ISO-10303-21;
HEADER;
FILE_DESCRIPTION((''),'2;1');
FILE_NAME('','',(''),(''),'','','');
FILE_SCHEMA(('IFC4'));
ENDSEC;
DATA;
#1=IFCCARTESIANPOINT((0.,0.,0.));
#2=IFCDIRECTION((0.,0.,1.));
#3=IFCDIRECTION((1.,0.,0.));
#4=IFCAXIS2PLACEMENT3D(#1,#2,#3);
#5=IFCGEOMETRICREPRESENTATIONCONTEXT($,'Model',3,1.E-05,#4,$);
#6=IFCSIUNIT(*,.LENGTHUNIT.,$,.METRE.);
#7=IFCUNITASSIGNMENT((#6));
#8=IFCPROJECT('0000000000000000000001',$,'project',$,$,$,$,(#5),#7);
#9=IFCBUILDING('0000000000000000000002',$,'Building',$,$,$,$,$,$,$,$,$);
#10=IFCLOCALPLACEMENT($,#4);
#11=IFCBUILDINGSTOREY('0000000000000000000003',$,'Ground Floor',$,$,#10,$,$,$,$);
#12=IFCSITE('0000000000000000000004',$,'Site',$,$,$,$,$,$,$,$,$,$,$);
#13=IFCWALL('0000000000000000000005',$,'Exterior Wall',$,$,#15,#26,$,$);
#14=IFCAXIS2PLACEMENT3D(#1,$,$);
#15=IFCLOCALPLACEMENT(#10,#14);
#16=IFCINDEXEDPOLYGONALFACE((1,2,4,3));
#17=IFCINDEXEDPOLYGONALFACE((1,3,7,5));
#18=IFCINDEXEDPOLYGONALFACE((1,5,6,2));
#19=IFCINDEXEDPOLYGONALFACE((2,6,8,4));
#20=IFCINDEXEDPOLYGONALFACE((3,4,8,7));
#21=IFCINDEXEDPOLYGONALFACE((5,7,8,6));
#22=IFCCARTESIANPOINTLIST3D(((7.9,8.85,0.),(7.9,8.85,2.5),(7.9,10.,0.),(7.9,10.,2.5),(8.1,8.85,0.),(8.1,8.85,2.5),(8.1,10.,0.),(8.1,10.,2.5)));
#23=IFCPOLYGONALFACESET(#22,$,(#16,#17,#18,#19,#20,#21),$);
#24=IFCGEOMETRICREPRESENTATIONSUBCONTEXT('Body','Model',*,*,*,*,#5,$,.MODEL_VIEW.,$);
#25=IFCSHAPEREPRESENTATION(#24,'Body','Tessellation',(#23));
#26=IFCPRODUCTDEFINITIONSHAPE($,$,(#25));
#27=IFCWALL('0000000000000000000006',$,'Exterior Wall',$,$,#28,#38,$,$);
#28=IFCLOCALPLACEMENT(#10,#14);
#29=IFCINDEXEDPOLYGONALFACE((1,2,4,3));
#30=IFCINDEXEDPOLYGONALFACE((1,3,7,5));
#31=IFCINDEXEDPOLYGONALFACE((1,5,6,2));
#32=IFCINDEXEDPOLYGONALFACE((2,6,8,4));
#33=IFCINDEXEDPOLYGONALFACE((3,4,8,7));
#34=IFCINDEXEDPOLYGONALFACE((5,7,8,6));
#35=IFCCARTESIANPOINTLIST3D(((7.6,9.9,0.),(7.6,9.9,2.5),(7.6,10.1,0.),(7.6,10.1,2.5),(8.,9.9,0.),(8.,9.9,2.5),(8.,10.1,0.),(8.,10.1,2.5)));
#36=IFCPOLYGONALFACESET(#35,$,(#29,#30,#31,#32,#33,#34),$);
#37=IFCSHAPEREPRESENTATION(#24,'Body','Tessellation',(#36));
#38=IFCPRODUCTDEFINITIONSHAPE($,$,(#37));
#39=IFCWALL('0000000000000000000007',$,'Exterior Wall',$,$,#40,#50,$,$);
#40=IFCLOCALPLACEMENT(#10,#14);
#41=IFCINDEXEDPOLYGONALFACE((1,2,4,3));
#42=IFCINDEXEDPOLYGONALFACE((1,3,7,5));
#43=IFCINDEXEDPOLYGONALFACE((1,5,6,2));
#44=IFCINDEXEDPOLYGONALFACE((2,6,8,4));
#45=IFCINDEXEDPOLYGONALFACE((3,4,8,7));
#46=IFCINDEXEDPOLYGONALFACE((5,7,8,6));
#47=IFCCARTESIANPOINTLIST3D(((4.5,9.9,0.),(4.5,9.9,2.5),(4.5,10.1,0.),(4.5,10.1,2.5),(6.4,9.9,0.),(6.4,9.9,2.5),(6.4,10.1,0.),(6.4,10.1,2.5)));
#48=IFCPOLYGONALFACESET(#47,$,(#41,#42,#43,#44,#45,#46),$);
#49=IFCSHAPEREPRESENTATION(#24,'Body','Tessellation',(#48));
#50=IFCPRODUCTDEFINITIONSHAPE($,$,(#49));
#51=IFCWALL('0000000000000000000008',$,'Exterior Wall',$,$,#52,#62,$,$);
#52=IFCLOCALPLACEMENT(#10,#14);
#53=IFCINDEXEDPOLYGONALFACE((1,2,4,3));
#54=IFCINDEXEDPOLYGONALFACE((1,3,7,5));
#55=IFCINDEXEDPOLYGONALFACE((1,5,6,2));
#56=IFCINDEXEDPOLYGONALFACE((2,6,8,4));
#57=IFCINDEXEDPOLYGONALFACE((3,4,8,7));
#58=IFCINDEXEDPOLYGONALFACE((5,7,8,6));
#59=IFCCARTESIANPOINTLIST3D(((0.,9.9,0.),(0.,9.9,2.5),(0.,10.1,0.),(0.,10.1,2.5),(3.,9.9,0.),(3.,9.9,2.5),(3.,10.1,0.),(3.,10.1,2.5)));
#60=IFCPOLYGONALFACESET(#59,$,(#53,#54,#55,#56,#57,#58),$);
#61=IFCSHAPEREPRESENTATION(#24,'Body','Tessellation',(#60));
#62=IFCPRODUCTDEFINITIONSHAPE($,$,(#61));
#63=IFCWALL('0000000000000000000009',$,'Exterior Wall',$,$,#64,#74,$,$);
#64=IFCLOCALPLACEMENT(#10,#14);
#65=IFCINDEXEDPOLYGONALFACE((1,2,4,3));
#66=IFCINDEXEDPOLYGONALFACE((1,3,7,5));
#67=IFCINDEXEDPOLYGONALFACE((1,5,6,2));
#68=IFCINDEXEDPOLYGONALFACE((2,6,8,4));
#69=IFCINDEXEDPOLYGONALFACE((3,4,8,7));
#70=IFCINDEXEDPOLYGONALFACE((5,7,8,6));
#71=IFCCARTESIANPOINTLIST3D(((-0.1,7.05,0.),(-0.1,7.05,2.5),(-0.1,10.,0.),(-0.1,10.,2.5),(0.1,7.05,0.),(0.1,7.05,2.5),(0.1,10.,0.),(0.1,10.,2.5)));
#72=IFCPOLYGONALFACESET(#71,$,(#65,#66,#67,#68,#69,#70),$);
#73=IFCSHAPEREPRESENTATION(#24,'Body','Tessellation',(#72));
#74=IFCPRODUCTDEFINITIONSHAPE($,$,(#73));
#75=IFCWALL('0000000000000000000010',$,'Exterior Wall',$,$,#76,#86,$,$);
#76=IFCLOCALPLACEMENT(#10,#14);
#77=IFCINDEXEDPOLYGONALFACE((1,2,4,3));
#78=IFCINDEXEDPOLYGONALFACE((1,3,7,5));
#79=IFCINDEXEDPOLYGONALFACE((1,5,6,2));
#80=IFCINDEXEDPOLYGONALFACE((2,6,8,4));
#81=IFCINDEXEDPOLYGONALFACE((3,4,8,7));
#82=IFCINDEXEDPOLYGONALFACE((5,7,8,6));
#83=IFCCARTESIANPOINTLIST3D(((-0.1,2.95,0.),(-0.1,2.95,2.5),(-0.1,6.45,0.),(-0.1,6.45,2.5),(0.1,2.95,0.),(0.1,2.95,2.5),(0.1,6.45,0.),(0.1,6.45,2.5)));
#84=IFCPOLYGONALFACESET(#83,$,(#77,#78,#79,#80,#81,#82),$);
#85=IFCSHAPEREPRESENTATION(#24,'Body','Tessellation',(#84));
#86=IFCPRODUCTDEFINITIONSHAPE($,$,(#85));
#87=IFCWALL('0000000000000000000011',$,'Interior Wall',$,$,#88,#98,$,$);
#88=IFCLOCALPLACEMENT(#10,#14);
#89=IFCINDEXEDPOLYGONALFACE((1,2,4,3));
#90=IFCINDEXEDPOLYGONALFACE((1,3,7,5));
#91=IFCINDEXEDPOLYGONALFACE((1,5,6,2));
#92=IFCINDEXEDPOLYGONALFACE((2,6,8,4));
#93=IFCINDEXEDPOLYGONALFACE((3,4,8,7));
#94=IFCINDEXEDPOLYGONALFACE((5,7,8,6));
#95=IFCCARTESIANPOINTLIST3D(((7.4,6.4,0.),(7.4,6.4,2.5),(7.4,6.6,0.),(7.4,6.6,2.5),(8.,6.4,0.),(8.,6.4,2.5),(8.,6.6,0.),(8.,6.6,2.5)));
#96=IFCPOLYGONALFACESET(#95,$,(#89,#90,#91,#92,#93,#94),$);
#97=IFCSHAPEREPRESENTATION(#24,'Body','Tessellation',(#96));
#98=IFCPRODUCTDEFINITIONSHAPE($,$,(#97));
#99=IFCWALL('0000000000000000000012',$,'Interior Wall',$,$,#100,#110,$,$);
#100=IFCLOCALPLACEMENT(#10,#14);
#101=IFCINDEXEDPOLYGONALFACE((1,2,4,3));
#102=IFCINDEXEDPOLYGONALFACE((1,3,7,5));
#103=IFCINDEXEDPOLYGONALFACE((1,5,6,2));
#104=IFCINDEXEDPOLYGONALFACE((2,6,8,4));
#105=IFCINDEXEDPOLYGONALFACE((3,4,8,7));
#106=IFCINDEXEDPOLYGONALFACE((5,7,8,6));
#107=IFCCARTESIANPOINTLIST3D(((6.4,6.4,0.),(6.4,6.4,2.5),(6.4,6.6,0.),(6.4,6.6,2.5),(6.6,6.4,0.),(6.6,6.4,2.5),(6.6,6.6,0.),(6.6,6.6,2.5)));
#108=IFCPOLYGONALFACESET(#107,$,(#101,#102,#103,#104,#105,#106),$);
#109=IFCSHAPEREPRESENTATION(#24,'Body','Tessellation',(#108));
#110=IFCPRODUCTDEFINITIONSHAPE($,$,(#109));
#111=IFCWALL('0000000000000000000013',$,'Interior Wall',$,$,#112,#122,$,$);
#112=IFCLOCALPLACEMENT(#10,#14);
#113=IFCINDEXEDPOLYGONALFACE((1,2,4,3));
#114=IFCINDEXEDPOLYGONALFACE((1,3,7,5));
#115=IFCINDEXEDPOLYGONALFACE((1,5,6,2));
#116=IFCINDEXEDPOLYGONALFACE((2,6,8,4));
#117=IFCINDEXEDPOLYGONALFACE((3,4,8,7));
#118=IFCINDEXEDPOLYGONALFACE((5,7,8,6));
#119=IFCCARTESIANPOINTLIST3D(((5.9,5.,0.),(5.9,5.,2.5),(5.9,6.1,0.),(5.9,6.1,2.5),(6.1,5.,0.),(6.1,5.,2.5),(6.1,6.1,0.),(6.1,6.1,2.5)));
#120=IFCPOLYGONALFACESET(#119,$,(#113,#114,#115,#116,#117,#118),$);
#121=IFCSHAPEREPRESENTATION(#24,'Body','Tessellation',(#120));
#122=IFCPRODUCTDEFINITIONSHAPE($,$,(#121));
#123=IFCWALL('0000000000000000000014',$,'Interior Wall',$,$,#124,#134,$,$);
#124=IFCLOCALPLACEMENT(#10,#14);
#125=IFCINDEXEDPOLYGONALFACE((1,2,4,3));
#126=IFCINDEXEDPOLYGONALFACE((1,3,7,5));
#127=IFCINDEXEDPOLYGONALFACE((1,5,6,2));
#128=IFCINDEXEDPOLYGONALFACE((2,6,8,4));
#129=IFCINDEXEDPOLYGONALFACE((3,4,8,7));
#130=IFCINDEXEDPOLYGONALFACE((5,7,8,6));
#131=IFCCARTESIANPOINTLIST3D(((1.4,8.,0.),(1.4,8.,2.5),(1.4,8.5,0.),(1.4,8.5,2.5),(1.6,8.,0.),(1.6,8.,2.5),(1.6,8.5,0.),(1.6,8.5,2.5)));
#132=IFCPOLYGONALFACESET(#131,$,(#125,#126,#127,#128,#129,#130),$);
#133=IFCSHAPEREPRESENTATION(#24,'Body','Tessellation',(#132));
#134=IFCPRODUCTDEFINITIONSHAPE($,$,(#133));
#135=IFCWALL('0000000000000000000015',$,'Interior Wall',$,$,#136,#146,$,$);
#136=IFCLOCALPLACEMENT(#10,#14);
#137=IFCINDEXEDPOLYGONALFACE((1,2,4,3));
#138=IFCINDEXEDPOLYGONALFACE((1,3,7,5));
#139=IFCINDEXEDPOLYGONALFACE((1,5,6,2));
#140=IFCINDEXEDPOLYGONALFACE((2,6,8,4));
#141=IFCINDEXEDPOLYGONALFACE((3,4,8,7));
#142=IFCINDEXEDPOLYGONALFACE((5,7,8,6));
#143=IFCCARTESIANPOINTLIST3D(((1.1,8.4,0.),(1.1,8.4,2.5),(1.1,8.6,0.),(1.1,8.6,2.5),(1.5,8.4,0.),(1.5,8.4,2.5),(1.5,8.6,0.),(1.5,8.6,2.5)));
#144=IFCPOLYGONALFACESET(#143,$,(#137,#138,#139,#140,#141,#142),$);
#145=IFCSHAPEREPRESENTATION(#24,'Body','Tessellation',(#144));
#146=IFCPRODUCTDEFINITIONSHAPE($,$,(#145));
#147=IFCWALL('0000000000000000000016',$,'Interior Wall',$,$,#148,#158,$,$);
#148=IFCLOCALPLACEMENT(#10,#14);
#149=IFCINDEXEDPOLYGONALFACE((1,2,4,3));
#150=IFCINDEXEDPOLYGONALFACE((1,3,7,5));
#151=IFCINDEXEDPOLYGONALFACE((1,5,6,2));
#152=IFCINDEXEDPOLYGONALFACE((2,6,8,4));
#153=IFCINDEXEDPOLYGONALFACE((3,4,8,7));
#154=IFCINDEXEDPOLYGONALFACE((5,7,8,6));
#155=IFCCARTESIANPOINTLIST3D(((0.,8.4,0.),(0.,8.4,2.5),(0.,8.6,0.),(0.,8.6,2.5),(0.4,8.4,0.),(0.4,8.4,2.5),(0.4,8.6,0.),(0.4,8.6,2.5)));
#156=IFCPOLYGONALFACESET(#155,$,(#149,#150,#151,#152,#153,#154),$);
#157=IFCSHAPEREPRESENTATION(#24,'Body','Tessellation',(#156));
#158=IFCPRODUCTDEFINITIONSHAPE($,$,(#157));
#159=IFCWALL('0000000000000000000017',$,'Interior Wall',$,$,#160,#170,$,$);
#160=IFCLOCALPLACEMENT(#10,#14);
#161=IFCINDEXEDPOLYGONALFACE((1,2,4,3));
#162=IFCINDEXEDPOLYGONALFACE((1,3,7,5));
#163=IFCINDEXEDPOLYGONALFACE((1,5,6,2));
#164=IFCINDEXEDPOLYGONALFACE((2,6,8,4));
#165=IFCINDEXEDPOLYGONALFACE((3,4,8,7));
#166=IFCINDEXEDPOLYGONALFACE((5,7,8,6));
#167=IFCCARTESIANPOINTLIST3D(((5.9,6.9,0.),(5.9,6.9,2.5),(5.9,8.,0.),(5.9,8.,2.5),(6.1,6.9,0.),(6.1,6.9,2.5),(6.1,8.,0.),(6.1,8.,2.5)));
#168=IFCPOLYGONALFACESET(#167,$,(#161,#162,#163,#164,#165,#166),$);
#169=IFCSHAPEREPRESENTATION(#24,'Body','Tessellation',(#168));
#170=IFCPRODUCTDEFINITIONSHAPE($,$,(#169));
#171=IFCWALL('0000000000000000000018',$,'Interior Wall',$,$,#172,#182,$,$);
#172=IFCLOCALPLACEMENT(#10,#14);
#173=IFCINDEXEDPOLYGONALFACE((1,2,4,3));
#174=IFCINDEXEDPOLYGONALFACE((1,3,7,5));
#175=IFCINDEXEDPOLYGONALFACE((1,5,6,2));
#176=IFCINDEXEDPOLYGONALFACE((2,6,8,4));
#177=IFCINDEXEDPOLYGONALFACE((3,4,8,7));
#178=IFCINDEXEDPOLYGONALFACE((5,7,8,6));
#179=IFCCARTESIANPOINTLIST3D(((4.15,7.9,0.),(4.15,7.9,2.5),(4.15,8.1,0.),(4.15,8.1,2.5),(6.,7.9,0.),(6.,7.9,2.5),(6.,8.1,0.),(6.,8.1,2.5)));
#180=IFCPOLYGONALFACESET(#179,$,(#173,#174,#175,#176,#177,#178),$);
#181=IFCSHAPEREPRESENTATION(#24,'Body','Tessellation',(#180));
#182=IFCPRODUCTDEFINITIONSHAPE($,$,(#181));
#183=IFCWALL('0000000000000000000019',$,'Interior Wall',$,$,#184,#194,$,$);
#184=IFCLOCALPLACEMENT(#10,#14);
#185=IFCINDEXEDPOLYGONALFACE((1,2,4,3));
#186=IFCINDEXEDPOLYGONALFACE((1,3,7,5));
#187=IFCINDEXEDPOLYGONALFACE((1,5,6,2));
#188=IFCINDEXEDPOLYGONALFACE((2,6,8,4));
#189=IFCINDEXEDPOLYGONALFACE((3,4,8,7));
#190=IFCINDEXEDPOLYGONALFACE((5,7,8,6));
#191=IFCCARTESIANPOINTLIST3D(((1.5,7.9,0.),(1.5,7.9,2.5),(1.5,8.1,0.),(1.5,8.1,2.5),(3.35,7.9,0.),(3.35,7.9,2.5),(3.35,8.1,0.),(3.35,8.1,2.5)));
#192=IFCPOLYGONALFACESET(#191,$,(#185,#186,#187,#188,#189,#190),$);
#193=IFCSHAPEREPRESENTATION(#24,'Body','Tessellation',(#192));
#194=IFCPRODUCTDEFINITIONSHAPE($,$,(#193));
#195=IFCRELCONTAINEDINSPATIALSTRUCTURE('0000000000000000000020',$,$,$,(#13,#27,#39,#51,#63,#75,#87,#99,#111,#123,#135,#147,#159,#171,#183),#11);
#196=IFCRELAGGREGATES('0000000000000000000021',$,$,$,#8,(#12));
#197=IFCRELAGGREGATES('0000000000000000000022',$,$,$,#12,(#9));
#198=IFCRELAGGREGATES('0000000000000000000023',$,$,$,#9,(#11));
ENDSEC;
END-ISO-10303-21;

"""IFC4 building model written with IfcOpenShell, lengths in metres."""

from ifc_helpers import new_model, si_unit, frame, origin_with_axes, place, context, subcontext, project, spatial, indexed_curve, outline, extrude, element, save


model = new_model("IFC4")

# Units and contexts
model_context = context("Model", 3, precision=1e-05, world=origin_with_axes())
body_context = subcontext(model_context, "Body", "Model", "MODEL_VIEW")
ifc_project = project(units=[si_unit("LENGTHUNIT", "METRE")], contexts=[model_context])

# Site, building, storey
site = spatial("IfcSite", under=ifc_project, Name="Site")
building = spatial("IfcBuilding", under=site, Name="Building")
storey_placement = place(None, origin_with_axes())
storey = spatial("IfcBuildingStorey", under=building, at=storey_placement, Name="Ground Floor")

# Walls
wall_1_placement = place(storey_placement, frame((8.0, 8.85, 0.0), z_axis=(0.0, 0.0, 1.0), x_axis=(0.0, 1.0, 0.0)))
element("IfcWall", 1, at=wall_1_placement, inside=storey, Name="Exterior Wall", context=body_context, shape_type="SweptSolid", body=[
    extrude(outline(indexed_curve([(0.0, 0.0), (0.0, 0.2), (1.15, 0.2), (1.15, 0.0), (0.0, 0.0)], self_intersect=False)), frame((0.0, -0.1, 0.0), z_axis=(0.0, 0.0, 1.0), x_axis=(1.0, 0.0, 0.0)), (0.0, 0.0, 1.0), 2.5),
])
wall_2_placement = place(storey_placement, frame((8.0, 10.0, 0.0), z_axis=(0.0, 0.0, 1.0), x_axis=(-1.0, 0.0, 0.0)))
element("IfcWall", 2, at=wall_2_placement, inside=storey, Name="Exterior Wall", context=body_context, shape_type="SweptSolid", body=[
    extrude(outline(indexed_curve([(0.0, 0.0), (0.0, 0.2), (0.4, 0.2), (0.4, 0.0), (0.0, 0.0)], self_intersect=False)), frame((0.0, -0.1, 0.0), z_axis=(0.0, 0.0, 1.0), x_axis=(1.0, 0.0, 0.0)), (0.0, 0.0, 1.0), 2.5),
])
wall_3_placement = place(storey_placement, frame((6.4, 10.0, 0.0), z_axis=(0.0, 0.0, 1.0), x_axis=(-1.0, 0.0, 0.0)))
element("IfcWall", 3, at=wall_3_placement, inside=storey, Name="Exterior Wall", context=body_context, shape_type="SweptSolid", body=[
    extrude(outline(indexed_curve([(0.0, 0.0), (0.0, 0.2), (1.9, 0.2), (1.9, 0.0), (0.0, 0.0)], self_intersect=False)), frame((0.0, -0.1, 0.0), z_axis=(0.0, 0.0, 1.0), x_axis=(1.0, 0.0, 0.0)), (0.0, 0.0, 1.0), 2.5),
])
wall_4_placement = place(storey_placement, frame((3.0, 10.0, 0.0), z_axis=(0.0, 0.0, 1.0), x_axis=(-1.0, 0.0, 0.0)))
element("IfcWall", 4, at=wall_4_placement, inside=storey, Name="Exterior Wall", context=body_context, shape_type="SweptSolid", body=[
    extrude(outline(indexed_curve([(0.0, 0.0), (0.0, 0.2), (3.0, 0.2), (3.0, 0.0), (0.0, 0.0)], self_intersect=False)), frame((0.0, -0.1, 0.0), z_axis=(0.0, 0.0, 1.0), x_axis=(1.0, 0.0, 0.0)), (0.0, 0.0, 1.0), 2.5),
])
wall_5_placement = place(storey_placement, frame((0.0, 10.0, 0.0), z_axis=(0.0, 0.0, 1.0), x_axis=(0.0, -1.0, 0.0)))
element("IfcWall", 5, at=wall_5_placement, inside=storey, Name="Exterior Wall", context=body_context, shape_type="SweptSolid", body=[
    extrude(outline(indexed_curve([(0.0, 0.0), (0.0, 0.2), (2.95, 0.2), (2.95, 0.0), (0.0, 0.0)], self_intersect=False)), frame((0.0, -0.1, 0.0), z_axis=(0.0, 0.0, 1.0), x_axis=(1.0, 0.0, 0.0)), (0.0, 0.0, 1.0), 2.5),
])
wall_6_placement = place(storey_placement, frame((0.0, 6.45, 0.0), z_axis=(0.0, 0.0, 1.0), x_axis=(0.0, -1.0, 0.0)))
element("IfcWall", 6, at=wall_6_placement, inside=storey, Name="Exterior Wall", context=body_context, shape_type="SweptSolid", body=[
    extrude(outline(indexed_curve([(0.0, 0.0), (0.0, 0.2), (3.5, 0.2), (3.5, 0.0), (0.0, 0.0)], self_intersect=False)), frame((0.0, -0.1, 0.0), z_axis=(0.0, 0.0, 1.0), x_axis=(1.0, 0.0, 0.0)), (0.0, 0.0, 1.0), 2.5),
])
wall_7_placement = place(storey_placement, frame((8.0, 6.5, 0.0), z_axis=(0.0, 0.0, 1.0), x_axis=(-1.0, 0.0, 0.0)))
element("IfcWall", 7, at=wall_7_placement, inside=storey, Name="Interior Wall", context=body_context, shape_type="SweptSolid", body=[
    extrude(outline(indexed_curve([(0.0, 0.0), (0.0, 0.2), (0.6, 0.2), (0.6, 0.0), (0.0, 0.0)], self_intersect=False)), frame((0.0, -0.1, 0.0), z_axis=(0.0, 0.0, 1.0), x_axis=(1.0, 0.0, 0.0)), (0.0, 0.0, 1.0), 2.5),
])
wall_8_placement = place(storey_placement, frame((6.6, 6.5, 0.0), z_axis=(0.0, 0.0, 1.0), x_axis=(-1.0, 0.0, 0.0)))
element("IfcWall", 8, at=wall_8_placement, inside=storey, Name="Interior Wall", context=body_context, shape_type="SweptSolid", body=[
    extrude(outline(indexed_curve([(0.0, 0.0), (0.0, 0.2), (0.2, 0.2), (0.2, 0.0), (0.0, 0.0)], self_intersect=False)), frame((0.0, -0.1, 0.0), z_axis=(0.0, 0.0, 1.0), x_axis=(1.0, 0.0, 0.0)), (0.0, 0.0, 1.0), 2.5),
])
wall_9_placement = place(storey_placement, frame((6.0, 6.1, 0.0), z_axis=(0.0, 0.0, 1.0), x_axis=(0.0, -1.0, 0.0)))
element("IfcWall", 9, at=wall_9_placement, inside=storey, Name="Interior Wall", context=body_context, shape_type="SweptSolid", body=[
    extrude(outline(indexed_curve([(0.0, 0.0), (0.0, 0.2), (1.1, 0.2), (1.1, 0.0), (0.0, 0.0)], self_intersect=False)), frame((0.0, -0.1, 0.0), z_axis=(0.0, 0.0, 1.0), x_axis=(1.0, 0.0, 0.0)), (0.0, 0.0, 1.0), 2.5),
])
wall_10_placement = place(storey_placement, frame((1.5, 8.0, 0.0), z_axis=(0.0, 0.0, 1.0), x_axis=(0.0, 1.0, 0.0)))
element("IfcWall", 10, at=wall_10_placement, inside=storey, Name="Interior Wall", context=body_context, shape_type="SweptSolid", body=[
    extrude(outline(indexed_curve([(0.0, 0.0), (0.0, 0.2), (0.5, 0.2), (0.5, 0.0), (0.0, 0.0)], self_intersect=False)), frame((0.0, -0.1, 0.0), z_axis=(0.0, 0.0, 1.0), x_axis=(1.0, 0.0, 0.0)), (0.0, 0.0, 1.0), 2.5),
])
for number, where, z_axis, x_axis, name in (
    (11, (1.5, 8.5, 0.0), (0.0, 0.0, 1.0), (-1.0, 0.0, 0.0), "Interior Wall"),
    (12, (0.4, 8.5, 0.0), (0.0, 0.0, 1.0), (-1.0, 0.0, 0.0), "Interior Wall"),
):
    element("IfcWall", number, at=place(storey_placement, frame(where, z_axis=z_axis, x_axis=x_axis)), inside=storey, Name=name, context=body_context, shape_type="SweptSolid", body=[
        extrude(outline(indexed_curve([(0.0, 0.0), (0.0, 0.2), (0.4, 0.2), (0.4, 0.0), (0.0, 0.0)], self_intersect=False)), frame((0.0, -0.1, 0.0), z_axis=(0.0, 0.0, 1.0), x_axis=(1.0, 0.0, 0.0)), (0.0, 0.0, 1.0), 2.5),
    ])
wall_11_placement = place(storey_placement, frame((6.0, 6.9, 0.0), z_axis=(0.0, 0.0, 1.0), x_axis=(0.0, 1.0, 0.0)))
element("IfcWall", 13, at=wall_11_placement, inside=storey, Name="Interior Wall", context=body_context, shape_type="SweptSolid", body=[
    extrude(outline(indexed_curve([(0.0, 0.0), (0.0, 0.2), (1.1, 0.2), (1.1, 0.0), (0.0, 0.0)], self_intersect=False)), frame((0.0, -0.1, 0.0), z_axis=(0.0, 0.0, 1.0), x_axis=(1.0, 0.0, 0.0)), (0.0, 0.0, 1.0), 2.5),
])
wall_12_placement = place(storey_placement, frame((6.0, 8.0, 0.0), z_axis=(0.0, 0.0, 1.0), x_axis=(-1.0, 0.0, 0.0)))
element("IfcWall", 14, at=wall_12_placement, inside=storey, Name="Interior Wall", context=body_context, shape_type="SweptSolid", body=[
    extrude(outline(indexed_curve([(0.0, 0.0), (0.0, 0.2), (1.85, 0.2), (1.85, 0.0), (0.0, 0.0)], self_intersect=False)), frame((0.0, -0.1, 0.0), z_axis=(0.0, 0.0, 1.0), x_axis=(1.0, 0.0, 0.0)), (0.0, 0.0, 1.0), 2.5),
])
wall_13_placement = place(storey_placement, frame((3.35, 8.0, 0.0), z_axis=(0.0, 0.0, 1.0), x_axis=(-1.0, 0.0, 0.0)))
element("IfcWall", 15, at=wall_13_placement, inside=storey, Name="Interior Wall", context=body_context, shape_type="SweptSolid", body=[
    extrude(outline(indexed_curve([(0.0, 0.0), (0.0, 0.2), (1.85, 0.2), (1.85, 0.0), (0.0, 0.0)], self_intersect=False)), frame((0.0, -0.1, 0.0), z_axis=(0.0, 0.0, 1.0), x_axis=(1.0, 0.0, 0.0)), (0.0, 0.0, 1.0), 2.5),
])

save(model, "model.ifc")
